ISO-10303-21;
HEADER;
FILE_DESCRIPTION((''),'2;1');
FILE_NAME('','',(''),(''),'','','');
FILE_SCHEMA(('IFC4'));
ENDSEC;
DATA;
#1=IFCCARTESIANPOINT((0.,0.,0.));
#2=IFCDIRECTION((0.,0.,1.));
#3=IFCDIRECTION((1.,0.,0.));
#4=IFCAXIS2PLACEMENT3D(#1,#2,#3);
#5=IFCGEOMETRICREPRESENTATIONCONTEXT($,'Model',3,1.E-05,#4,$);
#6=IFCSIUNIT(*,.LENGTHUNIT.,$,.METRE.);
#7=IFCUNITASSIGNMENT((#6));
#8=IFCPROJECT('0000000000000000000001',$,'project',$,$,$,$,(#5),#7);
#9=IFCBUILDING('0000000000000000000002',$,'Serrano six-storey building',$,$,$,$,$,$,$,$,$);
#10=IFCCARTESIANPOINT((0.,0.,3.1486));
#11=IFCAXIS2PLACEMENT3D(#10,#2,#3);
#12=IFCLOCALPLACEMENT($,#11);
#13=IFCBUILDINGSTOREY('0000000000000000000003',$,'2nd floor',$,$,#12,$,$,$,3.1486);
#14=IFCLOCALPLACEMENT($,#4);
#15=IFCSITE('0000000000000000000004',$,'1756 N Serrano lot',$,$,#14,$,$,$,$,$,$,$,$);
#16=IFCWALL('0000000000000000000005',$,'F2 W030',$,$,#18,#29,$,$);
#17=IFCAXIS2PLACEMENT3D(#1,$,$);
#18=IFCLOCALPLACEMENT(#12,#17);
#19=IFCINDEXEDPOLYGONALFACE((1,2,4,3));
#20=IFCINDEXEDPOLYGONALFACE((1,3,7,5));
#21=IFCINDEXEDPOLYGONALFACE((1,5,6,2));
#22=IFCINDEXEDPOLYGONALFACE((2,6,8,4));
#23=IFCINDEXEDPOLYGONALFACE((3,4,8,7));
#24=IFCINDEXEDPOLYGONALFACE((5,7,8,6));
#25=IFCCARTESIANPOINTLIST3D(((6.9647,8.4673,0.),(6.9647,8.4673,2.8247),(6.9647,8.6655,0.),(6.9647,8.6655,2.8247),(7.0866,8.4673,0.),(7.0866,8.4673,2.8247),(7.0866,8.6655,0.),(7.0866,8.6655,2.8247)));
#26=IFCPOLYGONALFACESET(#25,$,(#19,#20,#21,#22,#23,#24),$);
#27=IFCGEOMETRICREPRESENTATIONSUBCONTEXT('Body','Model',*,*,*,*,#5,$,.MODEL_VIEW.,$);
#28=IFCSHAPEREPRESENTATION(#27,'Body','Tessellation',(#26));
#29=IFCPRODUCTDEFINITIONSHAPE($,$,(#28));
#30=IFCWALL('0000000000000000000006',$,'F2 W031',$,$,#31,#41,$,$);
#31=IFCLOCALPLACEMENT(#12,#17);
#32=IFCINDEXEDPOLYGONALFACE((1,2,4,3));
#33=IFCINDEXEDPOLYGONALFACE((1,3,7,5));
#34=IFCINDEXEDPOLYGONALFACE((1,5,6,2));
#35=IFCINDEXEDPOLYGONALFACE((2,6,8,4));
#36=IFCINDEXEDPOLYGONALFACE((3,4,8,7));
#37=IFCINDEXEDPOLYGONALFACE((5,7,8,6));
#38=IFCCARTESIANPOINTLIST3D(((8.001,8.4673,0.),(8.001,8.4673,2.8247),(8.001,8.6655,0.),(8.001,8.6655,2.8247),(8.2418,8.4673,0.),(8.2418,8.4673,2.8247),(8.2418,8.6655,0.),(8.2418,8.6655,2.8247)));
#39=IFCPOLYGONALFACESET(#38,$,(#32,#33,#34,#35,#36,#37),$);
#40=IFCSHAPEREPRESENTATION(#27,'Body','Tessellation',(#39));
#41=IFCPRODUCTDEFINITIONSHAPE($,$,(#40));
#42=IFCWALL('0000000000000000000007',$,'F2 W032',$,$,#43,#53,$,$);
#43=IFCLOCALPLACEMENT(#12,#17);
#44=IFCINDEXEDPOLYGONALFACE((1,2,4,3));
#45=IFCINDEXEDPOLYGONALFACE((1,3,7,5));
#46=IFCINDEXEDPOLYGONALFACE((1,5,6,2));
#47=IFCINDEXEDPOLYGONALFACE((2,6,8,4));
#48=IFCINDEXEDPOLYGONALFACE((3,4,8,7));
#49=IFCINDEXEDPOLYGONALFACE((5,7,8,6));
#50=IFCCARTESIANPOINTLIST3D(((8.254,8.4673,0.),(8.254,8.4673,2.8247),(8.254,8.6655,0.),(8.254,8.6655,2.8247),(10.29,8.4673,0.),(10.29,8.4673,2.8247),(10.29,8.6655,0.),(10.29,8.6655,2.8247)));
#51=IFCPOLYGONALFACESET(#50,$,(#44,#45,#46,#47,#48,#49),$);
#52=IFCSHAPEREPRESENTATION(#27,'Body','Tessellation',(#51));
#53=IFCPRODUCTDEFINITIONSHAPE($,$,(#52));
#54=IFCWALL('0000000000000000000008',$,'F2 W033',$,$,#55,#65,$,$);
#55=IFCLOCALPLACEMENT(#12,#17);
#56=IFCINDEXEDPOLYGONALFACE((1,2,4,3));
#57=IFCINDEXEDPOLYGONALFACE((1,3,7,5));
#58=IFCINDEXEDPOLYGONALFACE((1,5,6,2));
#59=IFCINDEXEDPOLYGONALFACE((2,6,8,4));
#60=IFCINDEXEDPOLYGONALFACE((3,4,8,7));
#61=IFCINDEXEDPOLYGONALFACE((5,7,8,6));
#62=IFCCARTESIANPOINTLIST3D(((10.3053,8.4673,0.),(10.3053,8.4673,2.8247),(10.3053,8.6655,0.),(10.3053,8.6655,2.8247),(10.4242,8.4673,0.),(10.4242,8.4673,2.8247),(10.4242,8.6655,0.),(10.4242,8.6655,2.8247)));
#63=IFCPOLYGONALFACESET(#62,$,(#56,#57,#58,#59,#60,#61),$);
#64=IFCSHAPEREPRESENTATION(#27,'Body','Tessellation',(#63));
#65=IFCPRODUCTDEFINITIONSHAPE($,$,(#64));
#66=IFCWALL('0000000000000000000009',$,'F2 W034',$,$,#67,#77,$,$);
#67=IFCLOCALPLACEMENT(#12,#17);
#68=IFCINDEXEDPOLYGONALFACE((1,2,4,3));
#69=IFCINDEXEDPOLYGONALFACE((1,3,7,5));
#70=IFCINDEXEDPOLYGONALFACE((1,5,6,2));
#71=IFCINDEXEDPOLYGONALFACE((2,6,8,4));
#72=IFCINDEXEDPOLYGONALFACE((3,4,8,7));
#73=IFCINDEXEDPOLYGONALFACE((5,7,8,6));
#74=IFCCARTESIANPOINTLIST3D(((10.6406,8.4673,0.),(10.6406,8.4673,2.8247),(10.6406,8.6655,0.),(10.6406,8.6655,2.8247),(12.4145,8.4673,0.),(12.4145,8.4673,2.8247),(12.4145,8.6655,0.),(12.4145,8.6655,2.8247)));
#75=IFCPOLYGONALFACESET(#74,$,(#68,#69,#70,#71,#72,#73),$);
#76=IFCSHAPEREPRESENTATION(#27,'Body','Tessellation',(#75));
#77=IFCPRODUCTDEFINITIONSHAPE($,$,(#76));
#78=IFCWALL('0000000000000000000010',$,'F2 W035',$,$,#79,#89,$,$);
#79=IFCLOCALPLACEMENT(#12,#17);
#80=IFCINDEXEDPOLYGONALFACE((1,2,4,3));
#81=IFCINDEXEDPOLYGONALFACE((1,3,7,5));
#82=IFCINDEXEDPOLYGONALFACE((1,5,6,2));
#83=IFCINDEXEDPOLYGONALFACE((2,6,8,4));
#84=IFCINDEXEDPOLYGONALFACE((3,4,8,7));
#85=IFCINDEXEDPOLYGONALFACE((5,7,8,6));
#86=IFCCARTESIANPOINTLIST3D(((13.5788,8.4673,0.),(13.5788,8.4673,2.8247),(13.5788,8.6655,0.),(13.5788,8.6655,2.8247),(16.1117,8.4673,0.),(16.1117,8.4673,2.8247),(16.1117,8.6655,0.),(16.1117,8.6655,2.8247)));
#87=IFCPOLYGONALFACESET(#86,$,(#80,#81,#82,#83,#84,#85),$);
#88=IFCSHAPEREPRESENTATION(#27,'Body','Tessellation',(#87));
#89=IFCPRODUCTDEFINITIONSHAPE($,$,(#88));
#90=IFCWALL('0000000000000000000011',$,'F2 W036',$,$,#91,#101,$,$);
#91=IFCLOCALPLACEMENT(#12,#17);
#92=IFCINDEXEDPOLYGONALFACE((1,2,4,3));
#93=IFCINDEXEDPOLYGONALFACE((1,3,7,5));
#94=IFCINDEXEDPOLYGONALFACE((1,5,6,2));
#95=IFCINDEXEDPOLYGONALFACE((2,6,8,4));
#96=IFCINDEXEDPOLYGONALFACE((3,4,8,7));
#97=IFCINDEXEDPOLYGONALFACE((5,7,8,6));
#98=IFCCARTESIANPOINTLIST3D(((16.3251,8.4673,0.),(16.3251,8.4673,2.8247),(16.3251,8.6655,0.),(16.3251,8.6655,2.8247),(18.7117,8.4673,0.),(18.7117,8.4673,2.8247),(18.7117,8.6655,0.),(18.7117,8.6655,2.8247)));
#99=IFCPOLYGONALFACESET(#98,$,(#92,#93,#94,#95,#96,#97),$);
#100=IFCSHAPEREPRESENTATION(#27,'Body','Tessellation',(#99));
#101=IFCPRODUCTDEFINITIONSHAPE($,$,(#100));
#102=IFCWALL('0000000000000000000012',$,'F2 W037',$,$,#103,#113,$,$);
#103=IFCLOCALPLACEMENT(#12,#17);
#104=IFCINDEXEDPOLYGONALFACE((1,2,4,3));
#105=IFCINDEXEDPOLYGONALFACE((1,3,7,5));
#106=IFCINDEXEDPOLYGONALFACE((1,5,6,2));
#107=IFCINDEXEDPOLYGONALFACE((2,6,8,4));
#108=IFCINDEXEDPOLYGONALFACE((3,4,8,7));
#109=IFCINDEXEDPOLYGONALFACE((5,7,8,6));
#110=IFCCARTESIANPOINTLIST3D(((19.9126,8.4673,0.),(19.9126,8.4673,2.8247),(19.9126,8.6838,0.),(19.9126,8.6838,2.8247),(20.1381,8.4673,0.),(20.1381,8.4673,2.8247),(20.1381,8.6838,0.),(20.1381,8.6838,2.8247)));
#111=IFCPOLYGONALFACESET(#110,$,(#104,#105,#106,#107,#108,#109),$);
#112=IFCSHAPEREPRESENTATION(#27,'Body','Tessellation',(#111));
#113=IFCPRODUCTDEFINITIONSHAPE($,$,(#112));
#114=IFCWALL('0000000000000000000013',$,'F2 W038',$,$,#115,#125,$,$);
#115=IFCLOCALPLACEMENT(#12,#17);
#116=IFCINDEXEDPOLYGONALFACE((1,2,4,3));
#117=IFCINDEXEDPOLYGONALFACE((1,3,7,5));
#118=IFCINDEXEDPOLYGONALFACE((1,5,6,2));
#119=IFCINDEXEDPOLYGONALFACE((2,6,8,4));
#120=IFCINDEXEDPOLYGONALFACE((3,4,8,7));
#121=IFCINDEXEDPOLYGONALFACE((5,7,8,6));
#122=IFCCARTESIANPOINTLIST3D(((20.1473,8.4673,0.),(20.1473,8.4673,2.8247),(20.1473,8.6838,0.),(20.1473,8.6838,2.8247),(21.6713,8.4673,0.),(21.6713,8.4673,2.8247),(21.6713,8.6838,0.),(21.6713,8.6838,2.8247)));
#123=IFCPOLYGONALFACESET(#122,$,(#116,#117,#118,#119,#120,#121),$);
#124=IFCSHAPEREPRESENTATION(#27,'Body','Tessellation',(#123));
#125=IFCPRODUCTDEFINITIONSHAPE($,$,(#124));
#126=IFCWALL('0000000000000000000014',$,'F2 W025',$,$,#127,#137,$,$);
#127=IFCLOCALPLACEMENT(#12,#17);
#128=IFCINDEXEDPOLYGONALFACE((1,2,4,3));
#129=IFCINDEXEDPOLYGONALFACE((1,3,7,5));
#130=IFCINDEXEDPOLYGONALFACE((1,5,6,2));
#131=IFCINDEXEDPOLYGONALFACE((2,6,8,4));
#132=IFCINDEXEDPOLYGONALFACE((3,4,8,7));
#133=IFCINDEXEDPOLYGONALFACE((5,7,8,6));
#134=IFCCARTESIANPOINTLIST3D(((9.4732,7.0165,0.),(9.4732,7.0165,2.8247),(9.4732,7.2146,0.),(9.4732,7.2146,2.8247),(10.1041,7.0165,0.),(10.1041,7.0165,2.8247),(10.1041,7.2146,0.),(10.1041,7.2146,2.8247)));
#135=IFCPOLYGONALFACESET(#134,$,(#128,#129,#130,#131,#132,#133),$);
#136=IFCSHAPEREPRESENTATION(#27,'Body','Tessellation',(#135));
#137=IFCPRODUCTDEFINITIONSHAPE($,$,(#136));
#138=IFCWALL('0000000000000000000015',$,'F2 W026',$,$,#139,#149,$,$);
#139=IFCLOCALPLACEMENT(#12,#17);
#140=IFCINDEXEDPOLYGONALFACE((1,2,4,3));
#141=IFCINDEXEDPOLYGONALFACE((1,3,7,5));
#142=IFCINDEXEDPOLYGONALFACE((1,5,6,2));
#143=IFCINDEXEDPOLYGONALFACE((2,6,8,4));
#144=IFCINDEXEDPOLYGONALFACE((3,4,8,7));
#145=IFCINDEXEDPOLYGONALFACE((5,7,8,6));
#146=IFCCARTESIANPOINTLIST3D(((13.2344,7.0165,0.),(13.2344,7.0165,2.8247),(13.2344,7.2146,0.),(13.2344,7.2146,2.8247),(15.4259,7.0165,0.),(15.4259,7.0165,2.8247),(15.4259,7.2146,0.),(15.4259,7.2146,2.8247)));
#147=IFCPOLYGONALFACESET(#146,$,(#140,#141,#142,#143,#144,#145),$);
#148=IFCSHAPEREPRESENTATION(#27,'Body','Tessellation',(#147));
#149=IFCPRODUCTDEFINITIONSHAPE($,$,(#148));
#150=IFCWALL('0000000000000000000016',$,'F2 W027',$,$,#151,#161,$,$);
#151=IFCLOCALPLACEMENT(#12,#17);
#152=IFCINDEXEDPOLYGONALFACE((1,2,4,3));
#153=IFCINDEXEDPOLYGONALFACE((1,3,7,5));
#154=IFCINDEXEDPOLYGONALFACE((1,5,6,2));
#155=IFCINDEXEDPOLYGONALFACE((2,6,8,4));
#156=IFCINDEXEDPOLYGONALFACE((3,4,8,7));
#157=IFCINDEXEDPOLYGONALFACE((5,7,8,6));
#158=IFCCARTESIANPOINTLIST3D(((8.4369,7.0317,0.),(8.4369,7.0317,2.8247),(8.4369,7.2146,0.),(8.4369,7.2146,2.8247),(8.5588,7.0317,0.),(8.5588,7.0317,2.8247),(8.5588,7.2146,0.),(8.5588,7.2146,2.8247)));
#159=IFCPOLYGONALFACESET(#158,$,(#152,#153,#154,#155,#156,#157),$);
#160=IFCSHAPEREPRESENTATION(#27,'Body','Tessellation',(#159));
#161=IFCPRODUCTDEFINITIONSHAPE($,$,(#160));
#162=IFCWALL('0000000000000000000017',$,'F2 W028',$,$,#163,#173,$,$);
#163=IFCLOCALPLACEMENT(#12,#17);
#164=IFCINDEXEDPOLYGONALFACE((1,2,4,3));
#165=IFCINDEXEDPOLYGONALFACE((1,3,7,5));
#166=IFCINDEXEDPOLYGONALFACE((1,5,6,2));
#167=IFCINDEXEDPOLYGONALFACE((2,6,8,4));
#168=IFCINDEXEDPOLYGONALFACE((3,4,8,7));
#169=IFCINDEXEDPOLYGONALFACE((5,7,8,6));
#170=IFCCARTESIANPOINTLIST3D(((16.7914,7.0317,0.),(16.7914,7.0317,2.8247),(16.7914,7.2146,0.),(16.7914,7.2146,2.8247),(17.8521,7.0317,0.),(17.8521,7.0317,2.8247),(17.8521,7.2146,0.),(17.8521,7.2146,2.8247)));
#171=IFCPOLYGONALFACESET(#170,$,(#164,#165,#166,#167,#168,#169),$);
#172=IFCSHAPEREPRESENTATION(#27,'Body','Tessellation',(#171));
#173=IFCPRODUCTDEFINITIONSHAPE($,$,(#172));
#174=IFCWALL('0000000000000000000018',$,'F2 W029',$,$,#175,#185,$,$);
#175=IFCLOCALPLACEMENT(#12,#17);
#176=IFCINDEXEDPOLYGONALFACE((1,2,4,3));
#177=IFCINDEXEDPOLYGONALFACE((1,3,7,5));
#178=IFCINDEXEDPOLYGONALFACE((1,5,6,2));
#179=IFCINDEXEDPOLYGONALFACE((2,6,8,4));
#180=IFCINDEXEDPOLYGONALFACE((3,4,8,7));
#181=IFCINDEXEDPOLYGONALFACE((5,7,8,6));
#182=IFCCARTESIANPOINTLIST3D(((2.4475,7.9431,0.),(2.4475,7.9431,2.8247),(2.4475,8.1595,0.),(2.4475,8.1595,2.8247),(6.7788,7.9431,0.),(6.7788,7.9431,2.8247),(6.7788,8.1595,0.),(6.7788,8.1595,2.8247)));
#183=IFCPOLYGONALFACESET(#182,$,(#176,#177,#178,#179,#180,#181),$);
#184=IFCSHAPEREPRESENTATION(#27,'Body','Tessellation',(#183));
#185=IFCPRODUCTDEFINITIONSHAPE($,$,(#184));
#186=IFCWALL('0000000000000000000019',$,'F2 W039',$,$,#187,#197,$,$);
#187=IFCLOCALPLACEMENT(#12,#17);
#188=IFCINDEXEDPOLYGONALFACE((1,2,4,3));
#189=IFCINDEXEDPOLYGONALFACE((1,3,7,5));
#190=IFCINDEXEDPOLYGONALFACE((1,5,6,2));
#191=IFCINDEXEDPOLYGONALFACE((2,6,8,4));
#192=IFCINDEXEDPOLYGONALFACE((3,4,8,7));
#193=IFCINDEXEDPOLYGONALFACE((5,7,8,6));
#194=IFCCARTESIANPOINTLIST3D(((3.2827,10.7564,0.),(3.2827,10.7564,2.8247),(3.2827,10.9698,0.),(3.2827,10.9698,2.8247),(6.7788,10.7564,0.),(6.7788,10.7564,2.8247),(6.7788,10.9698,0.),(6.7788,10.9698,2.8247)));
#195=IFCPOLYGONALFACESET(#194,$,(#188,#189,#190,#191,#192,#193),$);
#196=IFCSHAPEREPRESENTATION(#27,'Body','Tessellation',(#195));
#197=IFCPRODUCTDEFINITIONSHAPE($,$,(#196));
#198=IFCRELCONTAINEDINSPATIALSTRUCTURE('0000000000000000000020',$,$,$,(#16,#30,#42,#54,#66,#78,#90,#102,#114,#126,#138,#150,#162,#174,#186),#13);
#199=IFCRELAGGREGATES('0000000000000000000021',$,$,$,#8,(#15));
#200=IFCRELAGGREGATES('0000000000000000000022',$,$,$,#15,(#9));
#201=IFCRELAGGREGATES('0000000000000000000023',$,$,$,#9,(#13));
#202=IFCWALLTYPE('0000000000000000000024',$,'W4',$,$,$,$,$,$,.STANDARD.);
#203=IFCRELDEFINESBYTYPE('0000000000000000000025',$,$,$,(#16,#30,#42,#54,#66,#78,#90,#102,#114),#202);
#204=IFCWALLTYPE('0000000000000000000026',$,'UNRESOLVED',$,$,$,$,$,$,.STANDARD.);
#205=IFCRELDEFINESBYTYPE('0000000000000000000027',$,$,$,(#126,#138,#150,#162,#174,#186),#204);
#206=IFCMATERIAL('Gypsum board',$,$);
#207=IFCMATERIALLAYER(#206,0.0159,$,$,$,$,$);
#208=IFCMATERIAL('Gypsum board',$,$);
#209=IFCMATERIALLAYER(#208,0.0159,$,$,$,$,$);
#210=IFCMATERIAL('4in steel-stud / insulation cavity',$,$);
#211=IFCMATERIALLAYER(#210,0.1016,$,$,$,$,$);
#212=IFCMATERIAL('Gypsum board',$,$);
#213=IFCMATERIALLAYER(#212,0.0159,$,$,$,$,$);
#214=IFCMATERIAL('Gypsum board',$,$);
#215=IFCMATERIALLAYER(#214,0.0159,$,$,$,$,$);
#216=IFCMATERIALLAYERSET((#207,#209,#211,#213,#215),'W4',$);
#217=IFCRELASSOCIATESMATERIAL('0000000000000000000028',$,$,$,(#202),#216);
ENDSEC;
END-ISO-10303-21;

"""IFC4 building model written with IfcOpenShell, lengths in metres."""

from ifc_helpers import new_model, si_unit, frame, origin_with_axes, place, context, subcontext, project, spatial, polyline, outline, extrude, material, layer, layer_set, type_object, element, save


model = new_model("IFC4")

# Units and contexts
model_context = context("Model", 3, precision=1e-05, world=origin_with_axes())
body_context = subcontext(model_context, "Body", "Model", "MODEL_VIEW")
ifc_project = project(units=[si_unit("LENGTHUNIT", "METRE")], contexts=[model_context])

# Site, building, storey
site_placement = place(None, origin_with_axes())
site = spatial("IfcSite", under=ifc_project, at=site_placement, Name="1756 N Serrano lot")
building = spatial("IfcBuilding", under=site, Name="Serrano six-storey building")
storey_placement = place(None, frame((0.0, 0.0, 3.1486), z_axis=(0.0, 0.0, 1.0), x_axis=(1.0, 0.0, 0.0)))
storey = spatial("IfcBuildingStorey", under=building, at=storey_placement, Name="2nd floor", Elevation=3.1486)

# Walls
ifc_material_1 = material(Name="Gypsum board")
ifc_layer_1 = layer(ifc_material_1, 0.0159)
ifc_material_2 = material(Name="Gypsum board")
ifc_layer_2 = layer(ifc_material_2, 0.0159)
ifc_material_3 = material(Name="4in steel-stud / insulation cavity")
ifc_layer_3 = layer(ifc_material_3, 0.1016)
ifc_material_4 = material(Name="Gypsum board")
ifc_layer_4 = layer(ifc_material_4, 0.0159)
ifc_material_5 = material(Name="Gypsum board")
ifc_layer_5 = layer(ifc_material_5, 0.0159)
ifc_layer_set = layer_set([ifc_layer_1, ifc_layer_2, ifc_layer_3, ifc_layer_4, ifc_layer_5], Name="W4")
wall_type_1 = type_object("IfcWallType", Name="W4", PredefinedType="STANDARD", material=ifc_layer_set)
wall_1_placement = place(storey_placement, frame((0.0, 0.0, -3.1486), z_axis=(0.0, 0.0, 1.0), x_axis=(1.0, 0.0, 0.0)))
element("IfcWall", 1, at=wall_1_placement, inside=storey, type_object=wall_type_1, Name="F2 W030", context=body_context, shape_type="SweptSolid", body=[
    extrude(outline(polyline([(7.0866, 8.6655), (7.0866, 8.4673), (6.9647, 8.4673), (6.9647, 8.6655), (7.0866, 8.6655)])), frame((0.0, 0.0, 3.1486)), (0.0, 0.0, 1.0), 2.8247),
])
wall_2_placement = place(storey_placement, frame((0.0, 0.0, -3.1486), z_axis=(0.0, 0.0, 1.0), x_axis=(1.0, 0.0, 0.0)))
element("IfcWall", 2, at=wall_2_placement, inside=storey, type_object=wall_type_1, Name="F2 W031", context=body_context, shape_type="SweptSolid", body=[
    extrude(outline(polyline([(8.2418, 8.6655), (8.2418, 8.4673), (8.001, 8.4673), (8.001, 8.6655), (8.2418, 8.6655)])), frame((0.0, 0.0, 3.1486)), (0.0, 0.0, 1.0), 2.8247),
])
wall_3_placement = place(storey_placement, frame((0.0, 0.0, -3.1486), z_axis=(0.0, 0.0, 1.0), x_axis=(1.0, 0.0, 0.0)))
element("IfcWall", 3, at=wall_3_placement, inside=storey, type_object=wall_type_1, Name="F2 W032", context=body_context, shape_type="SweptSolid", body=[
    extrude(outline(polyline([(10.29, 8.6655), (10.29, 8.4673), (8.254, 8.4673), (8.254, 8.6655), (10.29, 8.6655)])), frame((0.0, 0.0, 3.1486)), (0.0, 0.0, 1.0), 2.8247),
])
wall_4_placement = place(storey_placement, frame((0.0, 0.0, -3.1486), z_axis=(0.0, 0.0, 1.0), x_axis=(1.0, 0.0, 0.0)))
element("IfcWall", 4, at=wall_4_placement, inside=storey, type_object=wall_type_1, Name="F2 W033", context=body_context, shape_type="SweptSolid", body=[
    extrude(outline(polyline([(10.4242, 8.6655), (10.4242, 8.4673), (10.3053, 8.4673), (10.3053, 8.6655), (10.4242, 8.6655)])), frame((0.0, 0.0, 3.1486)), (0.0, 0.0, 1.0), 2.8247),
])
wall_5_placement = place(storey_placement, frame((0.0, 0.0, -3.1486), z_axis=(0.0, 0.0, 1.0), x_axis=(1.0, 0.0, 0.0)))
element("IfcWall", 5, at=wall_5_placement, inside=storey, type_object=wall_type_1, Name="F2 W034", context=body_context, shape_type="SweptSolid", body=[
    extrude(outline(polyline([(12.4145, 8.6655), (12.4145, 8.4673), (10.6406, 8.4673), (10.6406, 8.6655), (12.4145, 8.6655)])), frame((0.0, 0.0, 3.1486)), (0.0, 0.0, 1.0), 2.8247),
])
wall_6_placement = place(storey_placement, frame((0.0, 0.0, -3.1486), z_axis=(0.0, 0.0, 1.0), x_axis=(1.0, 0.0, 0.0)))
element("IfcWall", 6, at=wall_6_placement, inside=storey, type_object=wall_type_1, Name="F2 W035", context=body_context, shape_type="SweptSolid", body=[
    extrude(outline(polyline([(16.1117, 8.6655), (16.1117, 8.4673), (13.5788, 8.4673), (13.5788, 8.6655), (16.1117, 8.6655)])), frame((0.0, 0.0, 3.1486)), (0.0, 0.0, 1.0), 2.8247),
])
wall_7_placement = place(storey_placement, frame((0.0, 0.0, -3.1486), z_axis=(0.0, 0.0, 1.0), x_axis=(1.0, 0.0, 0.0)))
element("IfcWall", 7, at=wall_7_placement, inside=storey, type_object=wall_type_1, Name="F2 W036", context=body_context, shape_type="SweptSolid", body=[
    extrude(outline(polyline([(18.7117, 8.6655), (18.7117, 8.4673), (16.3251, 8.4673), (16.3251, 8.6655), (18.7117, 8.6655)])), frame((0.0, 0.0, 3.1486)), (0.0, 0.0, 1.0), 2.8247),
])
wall_8_placement = place(storey_placement, frame((0.0, 0.0, -3.1486), z_axis=(0.0, 0.0, 1.0), x_axis=(1.0, 0.0, 0.0)))
element("IfcWall", 8, at=wall_8_placement, inside=storey, type_object=wall_type_1, Name="F2 W037", context=body_context, shape_type="SweptSolid", body=[
    extrude(outline(polyline([(20.1381, 8.6838), (20.1381, 8.4673), (19.9126, 8.4673), (19.9126, 8.6838), (20.1381, 8.6838)])), frame((0.0, 0.0, 3.1486)), (0.0, 0.0, 1.0), 2.8247),
])
wall_9_placement = place(storey_placement, frame((0.0, 0.0, -3.1486), z_axis=(0.0, 0.0, 1.0), x_axis=(1.0, 0.0, 0.0)))
element("IfcWall", 9, at=wall_9_placement, inside=storey, type_object=wall_type_1, Name="F2 W038", context=body_context, shape_type="SweptSolid", body=[
    extrude(outline(polyline([(21.6713, 8.6838), (21.6713, 8.4673), (20.1473, 8.4673), (20.1473, 8.6838), (21.6713, 8.6838)])), frame((0.0, 0.0, 3.1486)), (0.0, 0.0, 1.0), 2.8247),
])
wall_type_2 = type_object("IfcWallType", Name="UNRESOLVED", PredefinedType="STANDARD")
wall_10_placement = place(storey_placement, frame((0.0, 0.0, -3.1486), z_axis=(0.0, 0.0, 1.0), x_axis=(1.0, 0.0, 0.0)))
element("IfcWall", 10, at=wall_10_placement, inside=storey, type_object=wall_type_2, Name="F2 W025", context=body_context, shape_type="SweptSolid", body=[
    extrude(outline(polyline([(10.1041, 7.2146), (10.1041, 7.0165), (9.4732, 7.0165), (9.4732, 7.2146), (10.1041, 7.2146)])), frame((0.0, 0.0, 3.1486)), (0.0, 0.0, 1.0), 2.8247),
])
wall_11_placement = place(storey_placement, frame((0.0, 0.0, -3.1486), z_axis=(0.0, 0.0, 1.0), x_axis=(1.0, 0.0, 0.0)))
element("IfcWall", 11, at=wall_11_placement, inside=storey, type_object=wall_type_2, Name="F2 W026", context=body_context, shape_type="SweptSolid", body=[
    extrude(outline(polyline([(15.4259, 7.2146), (15.4259, 7.0165), (13.2344, 7.0165), (13.2344, 7.2146), (15.4259, 7.2146)])), frame((0.0, 0.0, 3.1486)), (0.0, 0.0, 1.0), 2.8247),
])
wall_12_placement = place(storey_placement, frame((0.0, 0.0, -3.1486), z_axis=(0.0, 0.0, 1.0), x_axis=(1.0, 0.0, 0.0)))
element("IfcWall", 12, at=wall_12_placement, inside=storey, type_object=wall_type_2, Name="F2 W027", context=body_context, shape_type="SweptSolid", body=[
    extrude(outline(polyline([(8.5588, 7.2146), (8.5588, 7.0317), (8.4369, 7.0317), (8.4369, 7.2146), (8.5588, 7.2146)])), frame((0.0, 0.0, 3.1486)), (0.0, 0.0, 1.0), 2.8247),
])
wall_13_placement = place(storey_placement, frame((0.0, 0.0, -3.1486), z_axis=(0.0, 0.0, 1.0), x_axis=(1.0, 0.0, 0.0)))
element("IfcWall", 13, at=wall_13_placement, inside=storey, type_object=wall_type_2, Name="F2 W028", context=body_context, shape_type="SweptSolid", body=[
    extrude(outline(polyline([(17.8521, 7.2146), (17.8521, 7.0317), (16.7914, 7.0317), (16.7914, 7.2146), (17.8521, 7.2146)])), frame((0.0, 0.0, 3.1486)), (0.0, 0.0, 1.0), 2.8247),
])
wall_14_placement = place(storey_placement, frame((0.0, 0.0, -3.1486), z_axis=(0.0, 0.0, 1.0), x_axis=(1.0, 0.0, 0.0)))
element("IfcWall", 14, at=wall_14_placement, inside=storey, type_object=wall_type_2, Name="F2 W029", context=body_context, shape_type="SweptSolid", body=[
    extrude(outline(polyline([(6.7788, 8.1595), (6.7788, 7.9431), (2.4475, 7.9431), (2.4475, 8.1595), (6.7788, 8.1595)])), frame((0.0, 0.0, 3.1486)), (0.0, 0.0, 1.0), 2.8247),
])
wall_15_placement = place(storey_placement, frame((0.0, 0.0, -3.1486), z_axis=(0.0, 0.0, 1.0), x_axis=(1.0, 0.0, 0.0)))
element("IfcWall", 15, at=wall_15_placement, inside=storey, type_object=wall_type_2, Name="F2 W039", context=body_context, shape_type="SweptSolid", body=[
    extrude(outline(polyline([(6.7788, 10.9698), (6.7788, 10.7564), (3.2827, 10.7564), (3.2827, 10.9698), (6.7788, 10.9698)])), frame((0.0, 0.0, 3.1486)), (0.0, 0.0, 1.0), 2.8247),
])

save(model, "model.ifc")
